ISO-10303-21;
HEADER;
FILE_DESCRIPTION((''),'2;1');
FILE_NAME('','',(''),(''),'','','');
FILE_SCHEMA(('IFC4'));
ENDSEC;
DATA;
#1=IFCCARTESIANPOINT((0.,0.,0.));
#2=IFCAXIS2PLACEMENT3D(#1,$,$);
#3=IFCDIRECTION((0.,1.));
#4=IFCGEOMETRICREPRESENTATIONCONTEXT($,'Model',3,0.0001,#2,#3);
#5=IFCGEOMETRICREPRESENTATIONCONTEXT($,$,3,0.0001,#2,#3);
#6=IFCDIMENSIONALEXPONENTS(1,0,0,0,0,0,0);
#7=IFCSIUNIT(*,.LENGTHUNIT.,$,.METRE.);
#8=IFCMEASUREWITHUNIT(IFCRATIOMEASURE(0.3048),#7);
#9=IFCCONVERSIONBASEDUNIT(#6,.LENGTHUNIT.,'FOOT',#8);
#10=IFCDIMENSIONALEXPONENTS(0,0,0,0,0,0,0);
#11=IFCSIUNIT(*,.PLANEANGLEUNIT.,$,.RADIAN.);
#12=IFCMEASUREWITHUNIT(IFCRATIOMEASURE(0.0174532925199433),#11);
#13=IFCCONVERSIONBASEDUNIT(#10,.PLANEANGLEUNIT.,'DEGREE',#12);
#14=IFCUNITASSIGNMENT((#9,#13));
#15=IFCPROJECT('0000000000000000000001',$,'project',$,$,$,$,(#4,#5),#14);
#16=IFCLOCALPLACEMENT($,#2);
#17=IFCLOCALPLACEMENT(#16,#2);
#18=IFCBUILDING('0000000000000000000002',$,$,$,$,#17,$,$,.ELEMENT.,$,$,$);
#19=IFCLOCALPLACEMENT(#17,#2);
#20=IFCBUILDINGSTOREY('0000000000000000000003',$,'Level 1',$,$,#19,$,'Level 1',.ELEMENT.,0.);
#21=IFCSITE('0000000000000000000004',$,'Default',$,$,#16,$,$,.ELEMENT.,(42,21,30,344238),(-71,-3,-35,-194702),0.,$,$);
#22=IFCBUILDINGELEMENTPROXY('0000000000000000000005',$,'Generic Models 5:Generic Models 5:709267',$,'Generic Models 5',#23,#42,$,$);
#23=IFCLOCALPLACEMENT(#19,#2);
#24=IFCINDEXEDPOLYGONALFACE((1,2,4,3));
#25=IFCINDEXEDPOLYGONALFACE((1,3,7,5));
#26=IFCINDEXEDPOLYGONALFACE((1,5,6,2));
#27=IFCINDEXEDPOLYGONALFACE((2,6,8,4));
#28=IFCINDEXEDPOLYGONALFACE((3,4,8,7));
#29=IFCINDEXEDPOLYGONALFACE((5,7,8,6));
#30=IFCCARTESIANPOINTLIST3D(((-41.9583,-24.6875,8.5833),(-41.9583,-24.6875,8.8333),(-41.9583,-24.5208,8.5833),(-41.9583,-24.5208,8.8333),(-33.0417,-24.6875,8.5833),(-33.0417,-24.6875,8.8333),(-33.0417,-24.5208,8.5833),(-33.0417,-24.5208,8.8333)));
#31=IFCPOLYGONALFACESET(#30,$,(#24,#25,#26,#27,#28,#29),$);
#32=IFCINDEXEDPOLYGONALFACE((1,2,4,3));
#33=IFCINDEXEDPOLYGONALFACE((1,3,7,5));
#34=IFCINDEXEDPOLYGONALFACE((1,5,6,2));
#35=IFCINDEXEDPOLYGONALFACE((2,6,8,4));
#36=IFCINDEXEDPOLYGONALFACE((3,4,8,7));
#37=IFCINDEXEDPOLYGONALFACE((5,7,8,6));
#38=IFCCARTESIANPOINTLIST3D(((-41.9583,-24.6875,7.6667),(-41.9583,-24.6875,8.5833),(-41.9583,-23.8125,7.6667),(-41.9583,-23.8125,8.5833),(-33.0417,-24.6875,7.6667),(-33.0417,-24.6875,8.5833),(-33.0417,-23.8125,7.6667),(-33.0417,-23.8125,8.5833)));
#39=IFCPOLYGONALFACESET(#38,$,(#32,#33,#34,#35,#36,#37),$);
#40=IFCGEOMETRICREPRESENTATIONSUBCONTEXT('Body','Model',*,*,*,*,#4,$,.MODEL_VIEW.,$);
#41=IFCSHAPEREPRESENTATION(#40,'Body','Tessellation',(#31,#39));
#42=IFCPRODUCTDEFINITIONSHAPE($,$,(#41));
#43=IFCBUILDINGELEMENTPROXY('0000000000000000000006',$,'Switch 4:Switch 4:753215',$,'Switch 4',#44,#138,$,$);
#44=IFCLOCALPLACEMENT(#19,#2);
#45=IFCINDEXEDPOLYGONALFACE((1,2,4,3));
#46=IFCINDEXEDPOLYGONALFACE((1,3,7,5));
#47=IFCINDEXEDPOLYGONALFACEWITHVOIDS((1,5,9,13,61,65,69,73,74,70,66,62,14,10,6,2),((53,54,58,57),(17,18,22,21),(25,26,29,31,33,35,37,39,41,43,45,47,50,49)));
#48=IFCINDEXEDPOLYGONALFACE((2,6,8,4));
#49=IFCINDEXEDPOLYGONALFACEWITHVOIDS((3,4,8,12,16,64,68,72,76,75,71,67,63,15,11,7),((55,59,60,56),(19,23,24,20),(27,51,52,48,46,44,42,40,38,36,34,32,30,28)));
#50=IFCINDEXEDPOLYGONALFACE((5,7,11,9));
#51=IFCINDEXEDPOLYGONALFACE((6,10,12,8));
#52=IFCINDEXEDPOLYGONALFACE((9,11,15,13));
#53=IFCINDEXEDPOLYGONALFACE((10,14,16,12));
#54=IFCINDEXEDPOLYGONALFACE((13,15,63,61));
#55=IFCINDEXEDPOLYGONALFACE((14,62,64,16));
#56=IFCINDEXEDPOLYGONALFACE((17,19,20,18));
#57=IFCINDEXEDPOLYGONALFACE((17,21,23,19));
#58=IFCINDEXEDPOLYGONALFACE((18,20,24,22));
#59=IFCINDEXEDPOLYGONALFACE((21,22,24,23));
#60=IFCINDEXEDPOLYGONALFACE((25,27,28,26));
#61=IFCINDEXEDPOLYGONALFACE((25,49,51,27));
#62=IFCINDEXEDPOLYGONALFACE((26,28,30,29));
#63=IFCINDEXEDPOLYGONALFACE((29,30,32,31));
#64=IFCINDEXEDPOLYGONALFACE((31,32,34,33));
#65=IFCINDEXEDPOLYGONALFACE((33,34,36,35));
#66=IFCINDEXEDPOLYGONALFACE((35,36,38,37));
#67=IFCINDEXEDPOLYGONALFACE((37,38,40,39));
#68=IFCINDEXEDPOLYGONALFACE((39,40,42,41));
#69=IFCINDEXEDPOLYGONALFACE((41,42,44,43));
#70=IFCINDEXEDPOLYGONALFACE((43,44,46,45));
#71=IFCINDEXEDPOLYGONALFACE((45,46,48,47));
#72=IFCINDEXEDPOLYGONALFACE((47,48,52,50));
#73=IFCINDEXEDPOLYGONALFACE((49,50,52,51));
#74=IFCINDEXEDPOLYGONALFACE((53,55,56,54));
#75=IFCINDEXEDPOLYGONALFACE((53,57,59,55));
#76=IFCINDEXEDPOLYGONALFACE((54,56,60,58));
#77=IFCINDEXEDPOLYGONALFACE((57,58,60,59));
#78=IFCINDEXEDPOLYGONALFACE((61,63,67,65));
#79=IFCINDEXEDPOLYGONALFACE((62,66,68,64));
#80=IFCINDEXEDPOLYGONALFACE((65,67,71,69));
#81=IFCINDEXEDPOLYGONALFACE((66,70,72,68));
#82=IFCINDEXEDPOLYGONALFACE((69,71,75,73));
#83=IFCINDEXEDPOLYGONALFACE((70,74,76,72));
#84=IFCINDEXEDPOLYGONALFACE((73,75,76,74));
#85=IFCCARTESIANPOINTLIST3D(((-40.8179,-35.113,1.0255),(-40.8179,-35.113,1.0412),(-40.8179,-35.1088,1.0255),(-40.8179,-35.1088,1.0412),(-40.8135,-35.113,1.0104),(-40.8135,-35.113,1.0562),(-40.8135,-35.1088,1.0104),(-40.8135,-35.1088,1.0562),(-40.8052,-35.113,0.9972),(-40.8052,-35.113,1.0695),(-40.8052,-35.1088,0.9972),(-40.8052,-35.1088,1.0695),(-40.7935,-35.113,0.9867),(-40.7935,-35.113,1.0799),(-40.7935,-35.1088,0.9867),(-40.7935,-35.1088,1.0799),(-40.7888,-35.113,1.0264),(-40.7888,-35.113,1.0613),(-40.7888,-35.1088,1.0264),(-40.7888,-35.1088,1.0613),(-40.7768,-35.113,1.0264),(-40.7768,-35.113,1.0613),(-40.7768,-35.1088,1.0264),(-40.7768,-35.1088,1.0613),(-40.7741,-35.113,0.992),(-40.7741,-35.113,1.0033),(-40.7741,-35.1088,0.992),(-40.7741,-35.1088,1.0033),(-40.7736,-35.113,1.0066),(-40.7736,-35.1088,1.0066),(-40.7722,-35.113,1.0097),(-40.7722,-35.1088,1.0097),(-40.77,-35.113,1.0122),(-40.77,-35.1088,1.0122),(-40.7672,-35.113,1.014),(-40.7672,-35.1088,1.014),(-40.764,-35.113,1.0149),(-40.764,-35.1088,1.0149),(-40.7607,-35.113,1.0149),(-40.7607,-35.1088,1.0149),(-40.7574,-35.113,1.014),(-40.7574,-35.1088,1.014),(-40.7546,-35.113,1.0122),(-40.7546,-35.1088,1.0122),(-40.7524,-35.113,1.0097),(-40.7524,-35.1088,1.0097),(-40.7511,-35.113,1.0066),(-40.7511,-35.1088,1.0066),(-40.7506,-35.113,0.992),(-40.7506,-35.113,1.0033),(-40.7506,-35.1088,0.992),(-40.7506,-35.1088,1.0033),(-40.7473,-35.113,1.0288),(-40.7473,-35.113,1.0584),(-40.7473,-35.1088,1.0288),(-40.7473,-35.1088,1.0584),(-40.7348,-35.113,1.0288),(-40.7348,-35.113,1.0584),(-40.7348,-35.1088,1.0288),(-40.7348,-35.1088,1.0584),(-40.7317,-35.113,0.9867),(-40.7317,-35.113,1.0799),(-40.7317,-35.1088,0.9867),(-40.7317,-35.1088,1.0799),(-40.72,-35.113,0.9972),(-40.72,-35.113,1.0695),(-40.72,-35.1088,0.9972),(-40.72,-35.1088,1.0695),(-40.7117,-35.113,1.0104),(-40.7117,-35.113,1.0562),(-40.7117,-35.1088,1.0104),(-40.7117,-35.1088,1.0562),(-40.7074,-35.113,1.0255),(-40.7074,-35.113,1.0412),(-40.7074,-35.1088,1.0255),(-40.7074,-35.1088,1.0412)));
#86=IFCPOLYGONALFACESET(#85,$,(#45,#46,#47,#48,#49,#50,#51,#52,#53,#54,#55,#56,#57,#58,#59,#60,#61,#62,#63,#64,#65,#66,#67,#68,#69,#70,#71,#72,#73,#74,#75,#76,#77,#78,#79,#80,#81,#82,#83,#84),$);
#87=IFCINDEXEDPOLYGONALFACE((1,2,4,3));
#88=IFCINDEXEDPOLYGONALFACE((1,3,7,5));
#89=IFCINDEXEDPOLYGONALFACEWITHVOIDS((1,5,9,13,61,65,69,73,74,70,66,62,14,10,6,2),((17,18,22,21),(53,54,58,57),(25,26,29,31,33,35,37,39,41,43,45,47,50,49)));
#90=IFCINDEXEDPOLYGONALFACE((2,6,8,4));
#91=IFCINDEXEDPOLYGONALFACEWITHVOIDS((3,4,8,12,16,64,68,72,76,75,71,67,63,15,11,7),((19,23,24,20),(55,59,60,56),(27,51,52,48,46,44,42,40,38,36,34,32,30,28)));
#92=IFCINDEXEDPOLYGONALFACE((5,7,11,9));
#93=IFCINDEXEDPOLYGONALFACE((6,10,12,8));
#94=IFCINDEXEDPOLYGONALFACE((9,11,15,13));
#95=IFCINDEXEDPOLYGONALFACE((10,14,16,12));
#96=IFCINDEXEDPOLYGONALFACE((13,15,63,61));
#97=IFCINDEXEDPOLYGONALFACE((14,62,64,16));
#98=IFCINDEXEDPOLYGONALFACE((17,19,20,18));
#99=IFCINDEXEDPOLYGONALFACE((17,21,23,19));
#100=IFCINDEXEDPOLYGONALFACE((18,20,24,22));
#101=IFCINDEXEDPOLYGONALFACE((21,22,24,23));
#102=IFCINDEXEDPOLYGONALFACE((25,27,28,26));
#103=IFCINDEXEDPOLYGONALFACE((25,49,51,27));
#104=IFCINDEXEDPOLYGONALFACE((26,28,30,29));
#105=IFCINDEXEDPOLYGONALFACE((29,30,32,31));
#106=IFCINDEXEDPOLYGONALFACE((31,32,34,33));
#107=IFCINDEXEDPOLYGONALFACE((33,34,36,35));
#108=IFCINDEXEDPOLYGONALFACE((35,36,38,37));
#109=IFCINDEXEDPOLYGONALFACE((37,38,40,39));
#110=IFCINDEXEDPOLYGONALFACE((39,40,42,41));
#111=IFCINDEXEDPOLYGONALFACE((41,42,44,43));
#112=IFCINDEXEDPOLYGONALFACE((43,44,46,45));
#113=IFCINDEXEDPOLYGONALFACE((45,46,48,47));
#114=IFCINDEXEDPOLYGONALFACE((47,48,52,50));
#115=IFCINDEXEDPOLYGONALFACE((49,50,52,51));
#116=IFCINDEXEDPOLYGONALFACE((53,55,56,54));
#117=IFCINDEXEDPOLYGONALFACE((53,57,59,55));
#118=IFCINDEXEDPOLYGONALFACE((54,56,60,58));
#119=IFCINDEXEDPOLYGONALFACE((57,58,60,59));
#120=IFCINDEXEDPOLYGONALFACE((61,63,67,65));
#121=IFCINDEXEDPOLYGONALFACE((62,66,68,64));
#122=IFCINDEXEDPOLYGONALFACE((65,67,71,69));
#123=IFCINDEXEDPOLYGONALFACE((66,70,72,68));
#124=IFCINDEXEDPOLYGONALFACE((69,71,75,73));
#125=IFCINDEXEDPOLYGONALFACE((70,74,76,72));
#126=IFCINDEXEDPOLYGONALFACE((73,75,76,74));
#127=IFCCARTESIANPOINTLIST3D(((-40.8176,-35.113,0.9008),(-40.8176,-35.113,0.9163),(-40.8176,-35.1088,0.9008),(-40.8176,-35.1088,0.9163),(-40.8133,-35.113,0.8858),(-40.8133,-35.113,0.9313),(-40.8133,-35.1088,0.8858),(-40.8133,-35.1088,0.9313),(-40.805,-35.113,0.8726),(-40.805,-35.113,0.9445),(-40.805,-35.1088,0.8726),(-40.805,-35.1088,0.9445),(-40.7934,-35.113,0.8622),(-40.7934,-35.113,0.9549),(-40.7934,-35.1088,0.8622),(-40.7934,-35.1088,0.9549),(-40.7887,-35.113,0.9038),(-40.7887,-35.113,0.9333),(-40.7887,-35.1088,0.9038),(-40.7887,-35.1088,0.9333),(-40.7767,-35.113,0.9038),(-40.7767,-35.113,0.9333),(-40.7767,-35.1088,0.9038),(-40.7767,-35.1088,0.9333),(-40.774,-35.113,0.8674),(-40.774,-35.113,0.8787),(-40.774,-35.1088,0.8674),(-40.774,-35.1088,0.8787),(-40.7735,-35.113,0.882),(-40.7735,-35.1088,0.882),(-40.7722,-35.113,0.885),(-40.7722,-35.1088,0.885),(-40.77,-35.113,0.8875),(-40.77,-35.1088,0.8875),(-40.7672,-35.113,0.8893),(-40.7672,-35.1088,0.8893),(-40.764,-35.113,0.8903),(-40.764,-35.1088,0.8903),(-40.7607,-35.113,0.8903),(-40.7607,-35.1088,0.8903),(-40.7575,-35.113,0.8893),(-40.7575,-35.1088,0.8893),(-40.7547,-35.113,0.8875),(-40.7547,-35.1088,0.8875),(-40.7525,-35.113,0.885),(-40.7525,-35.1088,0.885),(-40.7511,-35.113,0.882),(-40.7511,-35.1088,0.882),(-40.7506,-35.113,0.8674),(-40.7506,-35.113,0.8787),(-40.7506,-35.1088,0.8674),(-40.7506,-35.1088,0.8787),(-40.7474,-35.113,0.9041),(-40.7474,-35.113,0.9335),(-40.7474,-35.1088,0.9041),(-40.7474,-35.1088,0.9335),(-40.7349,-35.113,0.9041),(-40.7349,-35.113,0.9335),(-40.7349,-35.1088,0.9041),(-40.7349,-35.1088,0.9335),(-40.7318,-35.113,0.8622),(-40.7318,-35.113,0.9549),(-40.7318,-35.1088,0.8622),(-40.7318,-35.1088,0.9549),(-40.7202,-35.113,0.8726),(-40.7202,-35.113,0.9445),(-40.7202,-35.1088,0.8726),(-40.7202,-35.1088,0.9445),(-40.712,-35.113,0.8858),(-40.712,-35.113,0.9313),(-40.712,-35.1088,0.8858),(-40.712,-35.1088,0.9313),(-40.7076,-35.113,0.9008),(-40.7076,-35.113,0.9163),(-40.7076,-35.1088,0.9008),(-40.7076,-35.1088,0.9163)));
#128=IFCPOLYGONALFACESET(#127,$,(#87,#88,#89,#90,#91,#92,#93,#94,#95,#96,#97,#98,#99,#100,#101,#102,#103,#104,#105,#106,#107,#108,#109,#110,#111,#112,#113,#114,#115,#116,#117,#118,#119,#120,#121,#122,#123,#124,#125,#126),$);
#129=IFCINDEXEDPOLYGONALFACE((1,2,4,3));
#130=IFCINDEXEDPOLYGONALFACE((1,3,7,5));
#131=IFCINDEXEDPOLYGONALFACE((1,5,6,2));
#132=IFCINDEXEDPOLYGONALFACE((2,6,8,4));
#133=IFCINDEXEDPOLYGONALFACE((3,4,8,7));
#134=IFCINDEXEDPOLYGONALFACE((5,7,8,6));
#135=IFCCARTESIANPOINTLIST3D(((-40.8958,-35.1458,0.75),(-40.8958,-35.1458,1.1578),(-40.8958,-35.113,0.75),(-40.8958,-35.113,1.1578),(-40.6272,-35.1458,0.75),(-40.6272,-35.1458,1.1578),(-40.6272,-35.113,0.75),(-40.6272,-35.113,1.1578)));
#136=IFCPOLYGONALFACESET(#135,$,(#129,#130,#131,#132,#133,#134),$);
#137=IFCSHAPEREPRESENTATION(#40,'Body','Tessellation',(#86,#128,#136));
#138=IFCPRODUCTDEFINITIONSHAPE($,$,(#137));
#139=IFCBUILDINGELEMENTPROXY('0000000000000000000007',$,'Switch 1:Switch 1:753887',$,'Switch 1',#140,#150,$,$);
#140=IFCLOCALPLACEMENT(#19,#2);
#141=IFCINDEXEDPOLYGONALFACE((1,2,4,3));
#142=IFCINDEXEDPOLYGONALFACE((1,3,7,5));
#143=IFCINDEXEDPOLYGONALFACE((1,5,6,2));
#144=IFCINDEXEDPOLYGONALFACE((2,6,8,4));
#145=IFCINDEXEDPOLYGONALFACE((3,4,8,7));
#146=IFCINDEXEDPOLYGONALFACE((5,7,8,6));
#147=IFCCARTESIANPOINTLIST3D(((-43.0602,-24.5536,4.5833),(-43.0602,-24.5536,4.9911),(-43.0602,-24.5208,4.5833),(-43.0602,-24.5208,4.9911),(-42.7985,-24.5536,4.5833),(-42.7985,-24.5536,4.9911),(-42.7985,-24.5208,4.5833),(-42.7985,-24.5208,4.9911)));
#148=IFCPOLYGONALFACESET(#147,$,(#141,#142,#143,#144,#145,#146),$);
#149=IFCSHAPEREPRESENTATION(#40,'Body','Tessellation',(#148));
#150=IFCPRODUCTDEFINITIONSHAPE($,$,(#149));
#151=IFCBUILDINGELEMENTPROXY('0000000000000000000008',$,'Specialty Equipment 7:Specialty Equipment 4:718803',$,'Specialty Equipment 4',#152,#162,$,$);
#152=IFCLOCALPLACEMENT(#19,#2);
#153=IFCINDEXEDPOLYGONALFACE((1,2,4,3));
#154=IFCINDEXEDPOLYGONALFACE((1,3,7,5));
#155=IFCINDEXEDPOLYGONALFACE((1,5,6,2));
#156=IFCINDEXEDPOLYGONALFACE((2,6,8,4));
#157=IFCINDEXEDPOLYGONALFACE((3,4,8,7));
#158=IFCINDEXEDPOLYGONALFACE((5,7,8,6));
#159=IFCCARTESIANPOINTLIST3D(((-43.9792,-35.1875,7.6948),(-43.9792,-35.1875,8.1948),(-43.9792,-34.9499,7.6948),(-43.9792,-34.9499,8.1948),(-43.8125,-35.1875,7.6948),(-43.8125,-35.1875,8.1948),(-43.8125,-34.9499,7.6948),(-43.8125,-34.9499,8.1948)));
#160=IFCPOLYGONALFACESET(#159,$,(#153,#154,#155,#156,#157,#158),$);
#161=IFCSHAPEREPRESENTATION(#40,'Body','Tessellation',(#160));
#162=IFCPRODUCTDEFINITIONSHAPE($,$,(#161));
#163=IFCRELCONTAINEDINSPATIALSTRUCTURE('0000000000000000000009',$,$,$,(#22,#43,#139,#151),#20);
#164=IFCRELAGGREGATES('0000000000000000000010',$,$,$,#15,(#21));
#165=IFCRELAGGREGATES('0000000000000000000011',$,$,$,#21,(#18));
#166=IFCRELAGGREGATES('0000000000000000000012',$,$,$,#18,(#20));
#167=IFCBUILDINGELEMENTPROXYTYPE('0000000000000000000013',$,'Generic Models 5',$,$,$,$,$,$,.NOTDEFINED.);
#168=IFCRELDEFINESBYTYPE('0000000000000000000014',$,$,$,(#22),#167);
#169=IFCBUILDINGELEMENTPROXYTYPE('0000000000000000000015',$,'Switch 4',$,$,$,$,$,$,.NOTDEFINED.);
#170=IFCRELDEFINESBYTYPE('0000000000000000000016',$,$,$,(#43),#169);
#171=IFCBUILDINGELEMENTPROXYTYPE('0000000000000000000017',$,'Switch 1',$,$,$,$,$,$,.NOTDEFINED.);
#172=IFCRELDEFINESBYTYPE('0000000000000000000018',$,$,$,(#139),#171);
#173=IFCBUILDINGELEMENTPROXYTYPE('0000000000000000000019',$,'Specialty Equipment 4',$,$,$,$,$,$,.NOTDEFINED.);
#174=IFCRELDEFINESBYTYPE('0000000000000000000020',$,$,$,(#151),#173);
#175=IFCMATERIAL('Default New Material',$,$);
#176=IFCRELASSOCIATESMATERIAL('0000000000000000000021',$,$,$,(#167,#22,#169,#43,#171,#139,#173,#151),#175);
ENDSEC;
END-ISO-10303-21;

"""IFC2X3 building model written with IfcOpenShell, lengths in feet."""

from ifc_helpers import new_model, entity, si_unit, converted_unit, direction, frame, frame_2d, origin, origin_2d_with_axis, place, context, subcontext, project, spatial, polyline, circle_curve, parameter, trimmed, segment, composite_curve, rectangle, outline, extrude, source, transform, mapped, material, type_object, type_shapes, element, save


model = new_model("IFC2X3")

# Units and contexts
model_context = context("Model", 3, precision=0.0001, world=origin(), true_north=direction((0.0, 1.0)))
context_of_model = context(None, 3, precision=0.0001, world=origin(), true_north=direction((0.0, 1.0)))
body_context = subcontext(model_context, "Body", "Model", "MODEL_VIEW")
ifc_project = project(units=[converted_unit("LENGTHUNIT", "FOOT", entity("IfcRatioMeasure", 0.3048), si_unit("LENGTHUNIT", "METRE"), dimensions=[1, 0, 0, 0, 0, 0, 0]), converted_unit("PLANEANGLEUNIT", "DEGREE", entity("IfcRatioMeasure", 0.0174532925199433), si_unit("PLANEANGLEUNIT", "RADIAN"), dimensions=[0, 0, 0, 0, 0, 0, 0])], contexts=[model_context, context_of_model])

# Site, building, storey
site_placement = place(None, origin())
site = spatial("IfcSite", under=ifc_project, at=site_placement, Name="Default", CompositionType="ELEMENT", RefLatitude=(42, 21, 30, 344238), RefLongitude=(-71, -3, -35, -194702), RefElevation=0.0)
building_placement = place(site_placement, origin())
building = spatial("IfcBuilding", under=site, at=building_placement, CompositionType="ELEMENT")
storey_placement = place(building_placement, origin())
storey = spatial("IfcBuildingStorey", under=building, at=storey_placement, Name="Level 1", LongName="Level 1", CompositionType="ELEMENT", Elevation=0.0)

# Shared definitions
ifc_material_1 = material(Name="Default New Material")

# Building element proxies
building_element_proxy_type_1 = type_object("IfcBuildingElementProxyType", Name="Generic Models 5", PredefinedType="NOTDEFINED", material=ifc_material_1)
shared_shape_1 = source(origin(), body_context, "Body", "SweptSolid", [
    extrude(rectangle(XDim=8.9167, YDim=0.1667, at=frame_2d((0.0, 0.0), x_axis=(1.0, 0.0))), frame((4.4583, 0.0833, 0.9167), z_axis=(0.0, 0.0, 1.0), x_axis=(-1.0, 0.0, 0.0)), (0.0, 0.0, 1.0), 0.25),
    extrude(rectangle(XDim=8.9167, YDim=0.875, at=frame_2d((0.0, 0.0), x_axis=(1.0, 0.0))), frame((4.4583, 0.4375, 0.0), z_axis=(0.0, 0.0, 1.0), x_axis=(-1.0, 0.0, 0.0)), (0.0, 0.0, 1.0), 0.9167),
])
type_shapes(building_element_proxy_type_1, [shared_shape_1])
proxy_1_placement = place(storey_placement, frame((-41.9583, -24.6875, 7.6667)))
element("IfcBuildingElementProxy", 1, at=proxy_1_placement, inside=storey, type_object=building_element_proxy_type_1, material=ifc_material_1, Name="Generic Models 5:Generic Models 5:709267", ObjectType="Generic Models 5", context=body_context, shape_type="MappedRepresentation", body=[
    mapped(shared_shape_1, transform((0.0, 0.0, 0.0), scale=1.0)),
])
building_element_proxy_type_2 = type_object("IfcBuildingElementProxyType", Name="Switch 4", PredefinedType="NOTDEFINED", material=ifc_material_1)
shared_shape_2 = source(origin(), body_context, "Body", "SweptSolid", [
    extrude(outline(composite_curve([segment(polyline([(-0.0309, -0.0466), (0.0309, -0.0466)]), True, "CONTINUOUS"), segment(trimmed(circle_curve(frame_2d((-0.0003, 0.0), x_axis=(-1.0, 0.0)), 0.0561), [parameter(123.794741)], [parameter(236.205259)], True, "PARAMETER"), True, "CONTINUOUS"), segment(polyline([(0.0309, 0.0466), (-0.0309, 0.0466)]), True, "CONTINUOUS"), segment(trimmed(circle_curve(frame_2d((0.0003, 0.0), x_axis=(1.0, 0.0)), 0.0561), [parameter(123.794741)], [parameter(236.205259)], True, "PARAMETER"), True, "CONTINUOUS")], self_intersect=False), holes=[polyline([(0.0142, 0.0279), (0.0262, 0.0279), (0.0262, -0.0069), (0.0142, -0.0069), (0.0142, 0.0279)]), polyline([(-0.0153, 0.025), (-0.0153, -0.0045), (-0.0278, -0.0045), (-0.0278, 0.025), (-0.0153, 0.025)]), composite_curve([segment(polyline([(-0.012, -0.0413), (-0.012, -0.03)]), True, "CONTINUOUS"), segment(trimmed(circle_curve(frame_2d((-0.0003, -0.03), x_axis=(-1.0, 0.0)), 0.0117), [parameter(180.0)], [parameter(0.0)], True, "PARAMETER"), False, "CONTINUOUS"), segment(polyline([(0.0115, -0.03), (0.0115, -0.0413)]), True, "CONTINUOUS"), segment(polyline([(0.0115, -0.0413), (-0.012, -0.0413)]), True, "CONTINUOUS")], self_intersect=False)]), frame((-0.0011, 0.0328, 0.2833), z_axis=(0.0, 1.0, 0.0), x_axis=(-1.0, 0.0, 0.0)), (0.0, 0.0, 1.0), 0.0042),
    extrude(outline(composite_curve([segment(polyline([(-0.0308, -0.0464), (0.0308, -0.0464)]), True, "CONTINUOUS"), segment(trimmed(circle_curve(frame_2d((-0.0003, 0.0), x_axis=(-1.0, 0.0)), 0.0558), [parameter(123.794741)], [parameter(236.205259)], True, "PARAMETER"), True, "CONTINUOUS"), segment(polyline([(0.0308, 0.0464), (-0.0308, 0.0464)]), True, "CONTINUOUS"), segment(trimmed(circle_curve(frame_2d((0.0003, 0.0), x_axis=(1.0, 0.0)), 0.0558), [parameter(123.794741)], [parameter(236.205259)], True, "PARAMETER"), True, "CONTINUOUS")], self_intersect=False), holes=[polyline([(0.0141, 0.0247), (0.026, 0.0247), (0.026, -0.0047), (0.0141, -0.0047), (0.0141, 0.0247)]), polyline([(-0.0152, 0.0249), (-0.0152, -0.0045), (-0.0277, -0.0045), (-0.0277, 0.0249), (-0.0152, 0.0249)]), composite_curve([segment(polyline([(-0.012, -0.0411), (-0.012, -0.0299)]), True, "CONTINUOUS"), segment(trimmed(circle_curve(frame_2d((-0.0003, -0.0299), x_axis=(-1.0, 0.0)), 0.0117), [parameter(180.0)], [parameter(0.0)], True, "PARAMETER"), False, "CONTINUOUS"), segment(polyline([(0.0114, -0.0299), (0.0114, -0.0411)]), True, "CONTINUOUS"), segment(polyline([(0.0114, -0.0411), (-0.012, -0.0411)]), True, "CONTINUOUS")], self_intersect=False)]), frame((-0.0011, 0.0328, 0.1586), z_axis=(0.0, 1.0, 0.0), x_axis=(-1.0, 0.0, 0.0)), (0.0, 0.0, 1.0), 0.0042),
    extrude(rectangle(XDim=0.0328, YDim=0.2687, at=origin_2d_with_axis()), frame((0.0, 0.0164, 0.0), z_axis=(0.0, 0.0, 1.0), x_axis=(0.0, -1.0, 0.0)), (0.0, 0.0, 1.0), 0.4078),
])
type_shapes(building_element_proxy_type_2, [shared_shape_2])
proxy_2_placement = place(storey_placement, frame((-40.7615, -35.1458, 0.75)))
element("IfcBuildingElementProxy", 2, at=proxy_2_placement, inside=storey, type_object=building_element_proxy_type_2, material=ifc_material_1, Name="Switch 4:Switch 4:753215", ObjectType="Switch 4", context=body_context, shape_type="MappedRepresentation", body=[
    mapped(shared_shape_2, transform((0.0, 0.0, 0.0), scale=1.0)),
])
building_element_proxy_type_3 = type_object("IfcBuildingElementProxyType", Name="Switch 1", PredefinedType="NOTDEFINED", material=ifc_material_1)
shared_shape_3 = source(origin(), body_context, "Body", "SweptSolid", [
    extrude(rectangle(XDim=0.0328, YDim=0.2617, at=origin_2d_with_axis()), frame((0.0, -0.0164, 0.0), z_axis=(0.0, 0.0, 1.0), x_axis=(0.0, 1.0, 0.0)), (0.0, 0.0, 1.0), 0.4078),
])
type_shapes(building_element_proxy_type_3, [shared_shape_3])
proxy_3_placement = place(storey_placement, frame((-42.9294, -24.5536, 4.5833), z_axis=(0.0, 0.0, 1.0), x_axis=(-1.0, 0.0, 0.0)))
element("IfcBuildingElementProxy", 3, at=proxy_3_placement, inside=storey, type_object=building_element_proxy_type_3, material=ifc_material_1, Name="Switch 1:Switch 1:753887", ObjectType="Switch 1", context=body_context, shape_type="MappedRepresentation", body=[
    mapped(shared_shape_3, transform((0.0, 0.0, 0.0), scale=1.0)),
])
building_element_proxy_type_4 = type_object("IfcBuildingElementProxyType", Name="Specialty Equipment 4", PredefinedType="NOTDEFINED", material=ifc_material_1)
shared_shape_4 = source(origin(), body_context, "Body", "SweptSolid", [
    extrude(rectangle(XDim=0.1667, YDim=0.2376, at=frame_2d((0.0, 0.0), x_axis=(1.0, 0.0))), frame((0.0833, 0.1188, 0.0), z_axis=(0.0, 0.0, 1.0), x_axis=(-1.0, 0.0, 0.0)), (0.0, 0.0, 1.0), 0.5),
])
type_shapes(building_element_proxy_type_4, [shared_shape_4])
proxy_4_placement = place(storey_placement, frame((-43.9792, -35.1875, 7.6948)))
element("IfcBuildingElementProxy", 4, at=proxy_4_placement, inside=storey, type_object=building_element_proxy_type_4, material=ifc_material_1, Name="Specialty Equipment 7:Specialty Equipment 4:718803", ObjectType="Specialty Equipment 4", context=body_context, shape_type="MappedRepresentation", body=[
    mapped(shared_shape_4, transform((0.0, 0.0, 0.0), scale=1.0)),
])

save(model, "model.ifc")
